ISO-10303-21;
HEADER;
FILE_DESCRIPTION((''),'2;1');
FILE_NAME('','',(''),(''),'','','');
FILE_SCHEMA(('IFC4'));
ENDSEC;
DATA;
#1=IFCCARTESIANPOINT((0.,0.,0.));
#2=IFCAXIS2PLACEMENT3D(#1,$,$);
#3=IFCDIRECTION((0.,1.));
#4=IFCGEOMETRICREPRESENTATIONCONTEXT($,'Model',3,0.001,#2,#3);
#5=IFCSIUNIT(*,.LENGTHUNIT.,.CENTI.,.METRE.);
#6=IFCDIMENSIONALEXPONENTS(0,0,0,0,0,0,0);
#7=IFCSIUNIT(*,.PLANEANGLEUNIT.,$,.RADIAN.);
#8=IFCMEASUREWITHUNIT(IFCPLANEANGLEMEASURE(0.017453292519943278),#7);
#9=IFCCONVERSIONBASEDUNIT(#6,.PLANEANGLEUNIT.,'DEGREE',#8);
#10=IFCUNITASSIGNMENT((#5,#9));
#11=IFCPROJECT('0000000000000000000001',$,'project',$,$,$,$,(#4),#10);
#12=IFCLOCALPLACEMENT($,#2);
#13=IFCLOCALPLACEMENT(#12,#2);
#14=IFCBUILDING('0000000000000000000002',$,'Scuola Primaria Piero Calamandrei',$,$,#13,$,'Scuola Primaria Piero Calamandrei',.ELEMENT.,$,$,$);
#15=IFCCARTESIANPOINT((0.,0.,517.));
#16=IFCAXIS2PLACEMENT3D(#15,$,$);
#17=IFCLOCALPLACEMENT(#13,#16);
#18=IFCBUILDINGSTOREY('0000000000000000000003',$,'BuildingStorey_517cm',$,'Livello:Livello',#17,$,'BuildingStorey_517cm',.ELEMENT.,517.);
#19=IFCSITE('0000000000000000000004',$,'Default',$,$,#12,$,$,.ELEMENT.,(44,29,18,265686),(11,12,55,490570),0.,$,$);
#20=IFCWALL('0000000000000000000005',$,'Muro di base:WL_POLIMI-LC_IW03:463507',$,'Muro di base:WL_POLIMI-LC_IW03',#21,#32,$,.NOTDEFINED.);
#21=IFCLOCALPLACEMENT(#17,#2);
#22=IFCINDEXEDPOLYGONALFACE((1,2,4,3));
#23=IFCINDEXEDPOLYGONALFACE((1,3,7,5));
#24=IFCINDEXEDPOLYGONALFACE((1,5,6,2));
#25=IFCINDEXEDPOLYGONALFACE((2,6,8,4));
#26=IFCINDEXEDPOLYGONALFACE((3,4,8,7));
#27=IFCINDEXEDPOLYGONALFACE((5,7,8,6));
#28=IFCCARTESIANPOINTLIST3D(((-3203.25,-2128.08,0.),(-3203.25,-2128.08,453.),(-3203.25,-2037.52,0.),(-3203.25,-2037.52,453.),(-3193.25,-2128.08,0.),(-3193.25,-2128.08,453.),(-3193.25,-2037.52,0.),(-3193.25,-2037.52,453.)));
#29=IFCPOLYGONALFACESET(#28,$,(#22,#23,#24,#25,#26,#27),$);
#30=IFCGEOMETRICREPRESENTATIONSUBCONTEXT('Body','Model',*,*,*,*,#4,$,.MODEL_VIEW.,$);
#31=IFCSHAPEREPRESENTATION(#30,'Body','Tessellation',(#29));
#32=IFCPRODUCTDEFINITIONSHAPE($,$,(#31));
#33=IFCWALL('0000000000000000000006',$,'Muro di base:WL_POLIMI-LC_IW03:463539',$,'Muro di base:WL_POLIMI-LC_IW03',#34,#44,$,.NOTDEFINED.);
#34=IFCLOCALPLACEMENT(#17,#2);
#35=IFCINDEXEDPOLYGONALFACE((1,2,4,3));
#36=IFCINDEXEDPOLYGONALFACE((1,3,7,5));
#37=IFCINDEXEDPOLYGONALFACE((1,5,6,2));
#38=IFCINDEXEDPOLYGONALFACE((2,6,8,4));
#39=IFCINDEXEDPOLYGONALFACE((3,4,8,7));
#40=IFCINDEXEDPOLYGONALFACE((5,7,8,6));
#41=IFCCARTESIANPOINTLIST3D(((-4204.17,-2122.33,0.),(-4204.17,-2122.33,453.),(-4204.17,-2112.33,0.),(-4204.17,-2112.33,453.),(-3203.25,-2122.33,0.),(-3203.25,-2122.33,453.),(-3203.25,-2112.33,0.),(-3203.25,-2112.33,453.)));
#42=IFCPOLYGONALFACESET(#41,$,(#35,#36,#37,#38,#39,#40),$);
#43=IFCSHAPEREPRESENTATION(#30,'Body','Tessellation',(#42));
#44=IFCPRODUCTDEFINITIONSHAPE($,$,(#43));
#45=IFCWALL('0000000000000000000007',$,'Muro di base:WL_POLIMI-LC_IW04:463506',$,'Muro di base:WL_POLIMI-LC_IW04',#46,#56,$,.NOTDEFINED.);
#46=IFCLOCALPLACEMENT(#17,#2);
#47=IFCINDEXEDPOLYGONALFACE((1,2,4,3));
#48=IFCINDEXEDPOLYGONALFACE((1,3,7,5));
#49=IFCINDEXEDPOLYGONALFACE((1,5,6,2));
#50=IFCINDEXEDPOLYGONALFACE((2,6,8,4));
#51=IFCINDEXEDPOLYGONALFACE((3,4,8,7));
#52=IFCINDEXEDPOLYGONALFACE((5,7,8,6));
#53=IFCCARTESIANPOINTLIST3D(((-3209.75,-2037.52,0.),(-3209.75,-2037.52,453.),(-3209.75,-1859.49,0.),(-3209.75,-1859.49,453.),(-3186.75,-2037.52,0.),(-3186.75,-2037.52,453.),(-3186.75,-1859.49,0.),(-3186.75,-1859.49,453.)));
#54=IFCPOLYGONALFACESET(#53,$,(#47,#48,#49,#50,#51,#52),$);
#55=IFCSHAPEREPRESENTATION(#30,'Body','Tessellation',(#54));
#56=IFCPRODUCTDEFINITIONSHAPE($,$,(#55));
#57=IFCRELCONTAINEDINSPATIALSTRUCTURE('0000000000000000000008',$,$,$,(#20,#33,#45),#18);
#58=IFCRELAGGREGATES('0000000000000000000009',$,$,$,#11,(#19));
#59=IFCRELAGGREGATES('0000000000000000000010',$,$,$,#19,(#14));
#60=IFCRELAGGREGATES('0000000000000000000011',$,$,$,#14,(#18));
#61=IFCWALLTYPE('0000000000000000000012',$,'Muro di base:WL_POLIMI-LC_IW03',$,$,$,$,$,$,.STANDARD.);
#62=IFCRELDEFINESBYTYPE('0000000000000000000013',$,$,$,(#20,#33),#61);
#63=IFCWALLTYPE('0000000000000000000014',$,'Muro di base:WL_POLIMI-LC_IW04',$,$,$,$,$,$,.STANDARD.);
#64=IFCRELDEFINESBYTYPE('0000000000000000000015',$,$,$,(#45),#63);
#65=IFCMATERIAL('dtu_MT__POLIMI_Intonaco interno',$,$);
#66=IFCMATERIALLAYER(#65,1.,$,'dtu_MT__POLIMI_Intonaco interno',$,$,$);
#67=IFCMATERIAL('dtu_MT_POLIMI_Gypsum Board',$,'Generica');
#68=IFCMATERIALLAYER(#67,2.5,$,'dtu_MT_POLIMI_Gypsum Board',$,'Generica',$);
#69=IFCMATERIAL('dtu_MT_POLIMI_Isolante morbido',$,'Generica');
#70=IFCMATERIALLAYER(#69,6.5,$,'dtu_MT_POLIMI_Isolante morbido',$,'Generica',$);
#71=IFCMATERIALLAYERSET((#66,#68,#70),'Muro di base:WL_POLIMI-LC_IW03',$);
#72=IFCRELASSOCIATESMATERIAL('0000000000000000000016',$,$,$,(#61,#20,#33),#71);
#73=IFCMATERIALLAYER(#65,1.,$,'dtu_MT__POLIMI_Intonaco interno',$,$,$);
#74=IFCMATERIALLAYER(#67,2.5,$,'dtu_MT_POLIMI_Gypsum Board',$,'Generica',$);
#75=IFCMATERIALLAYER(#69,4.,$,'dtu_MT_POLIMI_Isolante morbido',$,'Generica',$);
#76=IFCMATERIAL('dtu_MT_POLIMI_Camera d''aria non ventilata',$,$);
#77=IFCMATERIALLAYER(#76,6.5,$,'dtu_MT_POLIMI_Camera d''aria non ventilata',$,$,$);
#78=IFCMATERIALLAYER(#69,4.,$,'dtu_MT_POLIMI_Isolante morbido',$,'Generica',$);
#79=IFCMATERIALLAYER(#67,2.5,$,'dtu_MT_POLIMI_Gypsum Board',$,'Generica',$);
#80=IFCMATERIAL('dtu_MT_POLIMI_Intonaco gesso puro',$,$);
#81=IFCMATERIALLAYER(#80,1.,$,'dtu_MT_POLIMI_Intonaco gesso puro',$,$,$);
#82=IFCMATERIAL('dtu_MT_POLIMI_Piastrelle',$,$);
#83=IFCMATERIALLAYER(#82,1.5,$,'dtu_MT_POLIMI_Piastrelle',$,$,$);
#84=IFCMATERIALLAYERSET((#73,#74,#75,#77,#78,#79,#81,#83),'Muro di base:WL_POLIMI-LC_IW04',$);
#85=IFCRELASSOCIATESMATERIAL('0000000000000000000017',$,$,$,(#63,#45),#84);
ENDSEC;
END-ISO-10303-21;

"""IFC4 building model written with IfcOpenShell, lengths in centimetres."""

from ifc_helpers import new_model, entity, si_unit, converted_unit, direction, frame, frame_2d, origin, place, context, subcontext, project, spatial, rectangle, extrude, material, layer, layer_set, layer_usage, type_object, element, save


model = new_model("IFC4")

# Units and contexts
model_context = context("Model", 3, precision=0.001, world=origin(), true_north=direction((0.0, 1.0)))
body_context = subcontext(model_context, "Body", "Model", "MODEL_VIEW")
ifc_project = project(units=[si_unit("LENGTHUNIT", "METRE", prefix="CENTI"), converted_unit("PLANEANGLEUNIT", "DEGREE", entity("IfcPlaneAngleMeasure", 0.017453292519943278), si_unit("PLANEANGLEUNIT", "RADIAN"), dimensions=[0, 0, 0, 0, 0, 0, 0])], contexts=[model_context])

# Site, building, storey
site_placement = place(None, origin())
site = spatial("IfcSite", under=ifc_project, at=site_placement, Name="Default", CompositionType="ELEMENT", RefLatitude=(44, 29, 18, 265686), RefLongitude=(11, 12, 55, 490570), RefElevation=0.0)
building_placement = place(site_placement, origin())
building = spatial("IfcBuilding", under=site, at=building_placement, Name="Scuola Primaria Piero Calamandrei", LongName="Scuola Primaria Piero Calamandrei", CompositionType="ELEMENT")
storey_placement = place(building_placement, frame((0.0, 0.0, 517.0)))
storey = spatial("IfcBuildingStorey", under=building, at=storey_placement, Name="BuildingStorey_517cm", ObjectType="Livello:Livello", LongName="BuildingStorey_517cm", CompositionType="ELEMENT", Elevation=517.0)

# Shared definitions
ifc_material_1 = material(Name="dtu_MT_POLIMI_Isolante morbido", Category="Generica")
ifc_material_2 = material(Name="dtu_MT_POLIMI_Gypsum Board", Category="Generica")
ifc_material_3 = material(Name="dtu_MT__POLIMI_Intonaco interno")

# Shared definitions
ifc_material_4 = material(Name="dtu_MT_POLIMI_Camera d'aria non ventilata")
ifc_material_5 = material(Name="dtu_MT_POLIMI_Intonaco gesso puro")

# Walls
ifc_layer_1 = layer(ifc_material_3, 1.0, Name="dtu_MT__POLIMI_Intonaco interno")
ifc_layer_2 = layer(ifc_material_2, 2.5, Name="dtu_MT_POLIMI_Gypsum Board", Category="Generica")
ifc_layer_3 = layer(ifc_material_1, 6.5, Name="dtu_MT_POLIMI_Isolante morbido", Category="Generica")
ifc_layer_set_1 = layer_set([ifc_layer_1, ifc_layer_2, ifc_layer_3], Name="Muro di base:WL_POLIMI-LC_IW03")
ifc_layer_usage_1 = layer_usage(ifc_layer_set_1, "AXIS2", "NEGATIVE", 5.0)
wall_type_1 = type_object("IfcWallType", Name="Muro di base:WL_POLIMI-LC_IW03", PredefinedType="STANDARD", material=ifc_layer_set_1)
wall_1_placement = place(storey_placement, frame((-3198.25, -2128.08, 0.0), z_axis=(0.0, 0.0, 1.0), x_axis=(0.0, 1.0, 0.0)))
element("IfcWall", 1, at=wall_1_placement, inside=storey, type_object=wall_type_1, material=ifc_layer_usage_1, Name="Muro di base:WL_POLIMI-LC_IW03:463507", ObjectType="Muro di base:WL_POLIMI-LC_IW03", PredefinedType="NOTDEFINED", context=body_context, shape_type="SweptSolid", body=[
    extrude(rectangle(XDim=90.55, YDim=10.0, at=frame_2d((45.28, 0.0), x_axis=(-1.0, 0.0))), origin(), (0.0, 0.0, 1.0), 453.0),
])
ifc_layer_usage_2 = layer_usage(ifc_layer_set_1, "AXIS2", "NEGATIVE", 5.0)
wall_2_placement = place(storey_placement, frame((-4204.17, -2117.33, 0.0)))
element("IfcWall", 2, at=wall_2_placement, inside=storey, type_object=wall_type_1, material=ifc_layer_usage_2, Name="Muro di base:WL_POLIMI-LC_IW03:463539", ObjectType="Muro di base:WL_POLIMI-LC_IW03", PredefinedType="NOTDEFINED", context=body_context, shape_type="SweptSolid", body=[
    extrude(rectangle(XDim=1000.92, YDim=10.0, at=frame_2d((500.46, 0.0), x_axis=(-1.0, 0.0))), origin(), (0.0, 0.0, 1.0), 453.0),
])
ifc_layer_4 = layer(ifc_material_3, 1.0, Name="dtu_MT__POLIMI_Intonaco interno")
ifc_layer_5 = layer(ifc_material_2, 2.5, Name="dtu_MT_POLIMI_Gypsum Board", Category="Generica")
ifc_layer_6 = layer(ifc_material_1, 4.0, Name="dtu_MT_POLIMI_Isolante morbido", Category="Generica")
ifc_layer_7 = layer(ifc_material_4, 6.5, Name="dtu_MT_POLIMI_Camera d'aria non ventilata")
ifc_layer_8 = layer(ifc_material_1, 4.0, Name="dtu_MT_POLIMI_Isolante morbido", Category="Generica")
ifc_layer_9 = layer(ifc_material_2, 2.5, Name="dtu_MT_POLIMI_Gypsum Board", Category="Generica")
ifc_layer_10 = layer(ifc_material_5, 1.0, Name="dtu_MT_POLIMI_Intonaco gesso puro")
ifc_material_6 = material(Name="dtu_MT_POLIMI_Piastrelle")
ifc_layer_11 = layer(ifc_material_6, 1.5, Name="dtu_MT_POLIMI_Piastrelle")
ifc_layer_set_2 = layer_set([ifc_layer_4, ifc_layer_5, ifc_layer_6, ifc_layer_7, ifc_layer_8, ifc_layer_9, ifc_layer_10, ifc_layer_11], Name="Muro di base:WL_POLIMI-LC_IW04")
ifc_layer_usage_3 = layer_usage(ifc_layer_set_2, "AXIS2", "NEGATIVE", 11.5)
wall_type_2 = type_object("IfcWallType", Name="Muro di base:WL_POLIMI-LC_IW04", PredefinedType="STANDARD", material=ifc_layer_set_2)
wall_3_placement = place(storey_placement, frame((-3198.25, -2037.52, 0.0), z_axis=(0.0, 0.0, 1.0), x_axis=(0.0, 1.0, 0.0)))
element("IfcWall", 3, at=wall_3_placement, inside=storey, type_object=wall_type_2, material=ifc_layer_usage_3, Name="Muro di base:WL_POLIMI-LC_IW04:463506", ObjectType="Muro di base:WL_POLIMI-LC_IW04", PredefinedType="NOTDEFINED", context=body_context, shape_type="SweptSolid", body=[
    extrude(rectangle(XDim=178.04, YDim=23.0, at=frame_2d((89.02, 0.0), x_axis=(-1.0, 0.0))), origin(), (0.0, 0.0, 1.0), 453.0),
])

save(model, "model.ifc")
